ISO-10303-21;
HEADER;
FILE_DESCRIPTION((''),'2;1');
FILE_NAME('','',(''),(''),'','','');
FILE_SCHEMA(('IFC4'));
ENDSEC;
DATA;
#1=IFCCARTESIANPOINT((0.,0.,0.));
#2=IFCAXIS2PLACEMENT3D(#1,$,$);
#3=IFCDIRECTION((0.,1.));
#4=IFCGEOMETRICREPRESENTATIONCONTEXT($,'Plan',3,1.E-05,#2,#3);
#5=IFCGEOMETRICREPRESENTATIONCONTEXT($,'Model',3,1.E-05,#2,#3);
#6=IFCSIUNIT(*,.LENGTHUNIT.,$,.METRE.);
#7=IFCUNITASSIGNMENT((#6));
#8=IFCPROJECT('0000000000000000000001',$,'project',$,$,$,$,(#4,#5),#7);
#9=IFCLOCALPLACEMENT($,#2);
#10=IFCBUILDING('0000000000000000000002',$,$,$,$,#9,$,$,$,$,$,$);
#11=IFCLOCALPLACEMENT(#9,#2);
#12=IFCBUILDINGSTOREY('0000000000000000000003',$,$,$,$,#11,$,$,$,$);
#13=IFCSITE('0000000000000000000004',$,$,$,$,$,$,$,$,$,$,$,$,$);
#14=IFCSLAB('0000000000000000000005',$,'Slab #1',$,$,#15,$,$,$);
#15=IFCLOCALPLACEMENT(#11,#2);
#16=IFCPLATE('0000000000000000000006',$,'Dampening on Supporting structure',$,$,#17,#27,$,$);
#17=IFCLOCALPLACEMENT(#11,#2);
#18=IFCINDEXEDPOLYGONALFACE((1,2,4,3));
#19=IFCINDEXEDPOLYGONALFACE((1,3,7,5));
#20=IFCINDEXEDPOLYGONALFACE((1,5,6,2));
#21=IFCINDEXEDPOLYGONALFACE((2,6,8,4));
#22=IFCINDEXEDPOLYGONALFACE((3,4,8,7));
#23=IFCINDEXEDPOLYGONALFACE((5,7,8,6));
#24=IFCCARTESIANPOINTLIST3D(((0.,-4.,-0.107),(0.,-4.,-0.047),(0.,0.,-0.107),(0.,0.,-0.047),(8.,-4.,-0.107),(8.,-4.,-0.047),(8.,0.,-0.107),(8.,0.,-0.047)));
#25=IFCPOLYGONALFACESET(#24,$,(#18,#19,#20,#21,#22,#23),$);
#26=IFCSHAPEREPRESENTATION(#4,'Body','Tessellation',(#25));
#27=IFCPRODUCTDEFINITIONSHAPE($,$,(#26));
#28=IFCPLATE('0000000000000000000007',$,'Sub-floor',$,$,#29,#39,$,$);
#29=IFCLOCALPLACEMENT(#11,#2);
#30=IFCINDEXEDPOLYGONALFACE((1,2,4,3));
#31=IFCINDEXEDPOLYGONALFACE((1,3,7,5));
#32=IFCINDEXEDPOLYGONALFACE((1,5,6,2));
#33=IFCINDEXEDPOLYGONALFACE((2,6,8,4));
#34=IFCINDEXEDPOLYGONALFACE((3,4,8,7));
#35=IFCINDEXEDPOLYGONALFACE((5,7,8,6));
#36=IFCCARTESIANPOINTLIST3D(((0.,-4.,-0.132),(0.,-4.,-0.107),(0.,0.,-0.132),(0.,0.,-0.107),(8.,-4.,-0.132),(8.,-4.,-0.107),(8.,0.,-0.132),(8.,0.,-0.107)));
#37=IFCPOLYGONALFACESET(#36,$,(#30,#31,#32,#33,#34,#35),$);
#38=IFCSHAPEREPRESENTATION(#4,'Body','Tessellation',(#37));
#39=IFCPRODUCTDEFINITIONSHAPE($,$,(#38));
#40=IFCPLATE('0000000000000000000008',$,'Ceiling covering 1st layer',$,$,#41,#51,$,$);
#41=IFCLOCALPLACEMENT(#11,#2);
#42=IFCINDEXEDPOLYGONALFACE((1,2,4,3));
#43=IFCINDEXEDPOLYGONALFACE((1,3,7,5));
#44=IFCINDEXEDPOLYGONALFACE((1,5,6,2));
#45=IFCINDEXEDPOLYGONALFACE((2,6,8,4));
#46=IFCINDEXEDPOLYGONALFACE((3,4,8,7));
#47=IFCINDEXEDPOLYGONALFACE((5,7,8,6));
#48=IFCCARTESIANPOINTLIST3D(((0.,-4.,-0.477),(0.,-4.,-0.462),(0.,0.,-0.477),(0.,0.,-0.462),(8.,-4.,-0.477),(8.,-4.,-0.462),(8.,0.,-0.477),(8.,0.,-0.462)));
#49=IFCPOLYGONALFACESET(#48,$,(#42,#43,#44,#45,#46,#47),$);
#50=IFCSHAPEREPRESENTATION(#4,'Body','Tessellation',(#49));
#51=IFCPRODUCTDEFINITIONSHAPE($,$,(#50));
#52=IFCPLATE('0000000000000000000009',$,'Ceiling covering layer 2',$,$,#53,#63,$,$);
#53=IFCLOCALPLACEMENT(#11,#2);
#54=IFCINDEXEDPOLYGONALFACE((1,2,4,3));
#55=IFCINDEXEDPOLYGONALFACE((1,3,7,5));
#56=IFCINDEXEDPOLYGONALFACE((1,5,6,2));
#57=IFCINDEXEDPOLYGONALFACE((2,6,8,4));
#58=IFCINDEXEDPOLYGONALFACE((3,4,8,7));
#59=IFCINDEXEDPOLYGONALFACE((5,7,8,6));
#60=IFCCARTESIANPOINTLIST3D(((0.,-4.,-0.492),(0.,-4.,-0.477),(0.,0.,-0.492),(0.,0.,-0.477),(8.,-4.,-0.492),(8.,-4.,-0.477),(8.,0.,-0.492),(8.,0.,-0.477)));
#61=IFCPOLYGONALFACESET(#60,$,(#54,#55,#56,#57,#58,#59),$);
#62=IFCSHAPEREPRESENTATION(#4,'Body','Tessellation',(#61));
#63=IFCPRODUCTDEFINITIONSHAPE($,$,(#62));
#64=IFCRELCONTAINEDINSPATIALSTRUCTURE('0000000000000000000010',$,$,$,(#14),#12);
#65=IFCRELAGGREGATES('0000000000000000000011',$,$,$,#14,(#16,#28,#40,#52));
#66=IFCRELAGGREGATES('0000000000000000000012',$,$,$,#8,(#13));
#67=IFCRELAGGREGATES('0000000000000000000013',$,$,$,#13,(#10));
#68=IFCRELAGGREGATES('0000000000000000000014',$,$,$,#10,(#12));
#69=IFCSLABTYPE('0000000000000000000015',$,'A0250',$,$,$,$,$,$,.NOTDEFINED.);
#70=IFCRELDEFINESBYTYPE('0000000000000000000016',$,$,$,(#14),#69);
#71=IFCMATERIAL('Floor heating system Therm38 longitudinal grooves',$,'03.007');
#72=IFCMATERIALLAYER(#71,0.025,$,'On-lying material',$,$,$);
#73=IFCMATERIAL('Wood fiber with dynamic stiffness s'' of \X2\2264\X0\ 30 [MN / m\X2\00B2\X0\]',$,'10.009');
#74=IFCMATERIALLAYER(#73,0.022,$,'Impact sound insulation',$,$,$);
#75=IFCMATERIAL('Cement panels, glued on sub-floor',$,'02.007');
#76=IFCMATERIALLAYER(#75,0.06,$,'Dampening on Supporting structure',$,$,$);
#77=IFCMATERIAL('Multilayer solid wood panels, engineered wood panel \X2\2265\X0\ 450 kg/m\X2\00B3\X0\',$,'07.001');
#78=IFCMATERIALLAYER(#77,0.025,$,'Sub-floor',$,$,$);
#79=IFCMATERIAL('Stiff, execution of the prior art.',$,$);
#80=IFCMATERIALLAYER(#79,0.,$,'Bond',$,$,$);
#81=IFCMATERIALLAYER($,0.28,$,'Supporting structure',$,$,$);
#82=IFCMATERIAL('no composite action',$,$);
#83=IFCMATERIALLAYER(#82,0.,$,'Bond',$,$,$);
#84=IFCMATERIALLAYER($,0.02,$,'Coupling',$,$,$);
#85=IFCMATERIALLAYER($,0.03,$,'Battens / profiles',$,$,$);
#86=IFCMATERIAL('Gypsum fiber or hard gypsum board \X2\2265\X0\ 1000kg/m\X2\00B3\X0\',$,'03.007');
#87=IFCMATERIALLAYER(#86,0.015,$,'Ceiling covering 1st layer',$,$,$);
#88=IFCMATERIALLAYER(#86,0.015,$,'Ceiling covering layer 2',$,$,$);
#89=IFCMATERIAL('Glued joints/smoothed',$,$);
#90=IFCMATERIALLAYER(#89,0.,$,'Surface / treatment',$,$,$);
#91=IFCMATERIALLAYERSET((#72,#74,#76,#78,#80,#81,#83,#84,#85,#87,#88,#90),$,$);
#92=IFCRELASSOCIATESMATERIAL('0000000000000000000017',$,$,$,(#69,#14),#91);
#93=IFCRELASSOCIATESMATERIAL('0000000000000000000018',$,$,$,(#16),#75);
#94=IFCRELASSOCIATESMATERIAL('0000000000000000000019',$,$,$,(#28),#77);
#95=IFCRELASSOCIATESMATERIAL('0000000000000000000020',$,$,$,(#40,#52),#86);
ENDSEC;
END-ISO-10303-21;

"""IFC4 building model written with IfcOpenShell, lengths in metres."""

from ifc_helpers import new_model, si_unit, direction, frame, frame_2d, origin, place, context, project, spatial, rectangle, extrude, material, layer, layer_set, type_object, element, aggregate, save


model = new_model("IFC4")

# Units and contexts
plan_context = context("Plan", 3, precision=1e-05, world=origin(), true_north=direction((0.0, 1.0)))
model_context = context("Model", 3, precision=1e-05, world=origin(), true_north=direction((0.0, 1.0)))
ifc_project = project(units=[si_unit("LENGTHUNIT", "METRE")], contexts=[plan_context, model_context])

# Site, building, storey
site = spatial("IfcSite", under=ifc_project)
building_placement = place(None, origin())
building = spatial("IfcBuilding", under=site, at=building_placement)
storey_placement = place(building_placement, origin())
storey = spatial("IfcBuildingStorey", under=building, at=storey_placement)

# Slab, plates
ifc_material_1 = material(Name="Floor heating system Therm38 longitudinal grooves", Category="03.007")
ifc_layer_1 = layer(ifc_material_1, 0.025, Name="On-lying material")
ifc_material_2 = material(Name="Wood fiber with dynamic stiffness s' of ≤ 30 [MN / m²]", Category="10.009")
ifc_layer_2 = layer(ifc_material_2, 0.022, Name="Impact sound insulation")
ifc_material_3 = material(Name="Cement panels, glued on sub-floor", Category="02.007")
ifc_layer_3 = layer(ifc_material_3, 0.06, Name="Dampening on Supporting structure")
ifc_material_4 = material(Name="Multilayer solid wood panels, engineered wood panel ≥ 450 kg/m³", Category="07.001")
ifc_layer_4 = layer(ifc_material_4, 0.025, Name="Sub-floor")
ifc_material_5 = material(Name="Stiff, execution of the prior art.")
ifc_layer_5 = layer(ifc_material_5, 0.0, Name="Bond")
ifc_layer_6 = layer(None, 0.28, Name="Supporting structure")
ifc_material_6 = material(Name="no composite action")
ifc_layer_7 = layer(ifc_material_6, 0.0, Name="Bond")
ifc_layer_8 = layer(None, 0.02, Name="Coupling")
ifc_layer_9 = layer(None, 0.03, Name="Battens / profiles")
ifc_material_7 = material(Name="Gypsum fiber or hard gypsum board ≥ 1000kg/m³", Category="03.007")
ifc_layer_10 = layer(ifc_material_7, 0.015, Name="Ceiling covering 1st layer")
ifc_layer_11 = layer(ifc_material_7, 0.015, Name="Ceiling covering layer 2")
ifc_material_8 = material(Name="Glued joints/smoothed")
ifc_layer_12 = layer(ifc_material_8, 0.0, Name="Surface / treatment")
ifc_layer_set = layer_set([ifc_layer_1, ifc_layer_2, ifc_layer_3, ifc_layer_4, ifc_layer_5, ifc_layer_6, ifc_layer_7, ifc_layer_8, ifc_layer_9, ifc_layer_10, ifc_layer_11, ifc_layer_12])
slab_type = type_object("IfcSlabType", Name="A0250", PredefinedType="NOTDEFINED", material=ifc_layer_set)
slab_placement = place(None, frame((0.0, 0.0, 0.0), z_axis=(0.0, 0.0, -1.0), x_axis=(1.0, 0.0, 0.0)))
slab = element("IfcSlab", 1, at=slab_placement, inside=storey, type_object=slab_type, material=ifc_layer_set, Name="Slab #1")
plate_1_placement = place(slab_placement, origin())
plate_1 = element("IfcPlate", 2, at=plate_1_placement, material=ifc_material_3, Name="Dampening on Supporting structure", context=plan_context, shape_type="SweptSolid", body=[
    extrude(rectangle(XDim=8.0, YDim=4.0, at=frame_2d((4.0, 2.0), x_axis=(1.0, 0.0))), frame((0.0, 0.0, 0.047), z_axis=(0.0, 0.0, 1.0), x_axis=(1.0, 0.0, 0.0)), (0.0, 0.0, 1.0), 0.06),
])
plate_2_placement = place(slab_placement, origin())
plate_2 = element("IfcPlate", 3, at=plate_2_placement, material=ifc_material_4, Name="Sub-floor", context=plan_context, shape_type="SweptSolid", body=[
    extrude(rectangle(XDim=8.0, YDim=4.0, at=frame_2d((4.0, 2.0), x_axis=(1.0, 0.0))), frame((0.0, 0.0, 0.107), z_axis=(0.0, 0.0, 1.0), x_axis=(1.0, 0.0, 0.0)), (0.0, 0.0, 1.0), 0.025),
])
plate_3_placement = place(slab_placement, origin())
plate_3 = element("IfcPlate", 4, at=plate_3_placement, material=ifc_material_7, Name="Ceiling covering 1st layer", context=plan_context, shape_type="SweptSolid", body=[
    extrude(rectangle(XDim=8.0, YDim=4.0, at=frame_2d((4.0, 2.0), x_axis=(1.0, 0.0))), frame((0.0, 0.0, 0.462), z_axis=(0.0, 0.0, 1.0), x_axis=(1.0, 0.0, 0.0)), (0.0, 0.0, 1.0), 0.015),
])
plate_4_placement = place(slab_placement, origin())
plate_4 = element("IfcPlate", 5, at=plate_4_placement, material=ifc_material_7, Name="Ceiling covering layer 2", context=plan_context, shape_type="SweptSolid", body=[
    extrude(rectangle(XDim=8.0, YDim=4.0, at=frame_2d((4.0, 2.0), x_axis=(1.0, 0.0))), frame((0.0, 0.0, 0.477), z_axis=(0.0, 0.0, 1.0), x_axis=(1.0, 0.0, 0.0)), (0.0, 0.0, 1.0), 0.015),
])
aggregate(slab, [plate_1, plate_2, plate_3, plate_4])

save(model, "model.ifc")
